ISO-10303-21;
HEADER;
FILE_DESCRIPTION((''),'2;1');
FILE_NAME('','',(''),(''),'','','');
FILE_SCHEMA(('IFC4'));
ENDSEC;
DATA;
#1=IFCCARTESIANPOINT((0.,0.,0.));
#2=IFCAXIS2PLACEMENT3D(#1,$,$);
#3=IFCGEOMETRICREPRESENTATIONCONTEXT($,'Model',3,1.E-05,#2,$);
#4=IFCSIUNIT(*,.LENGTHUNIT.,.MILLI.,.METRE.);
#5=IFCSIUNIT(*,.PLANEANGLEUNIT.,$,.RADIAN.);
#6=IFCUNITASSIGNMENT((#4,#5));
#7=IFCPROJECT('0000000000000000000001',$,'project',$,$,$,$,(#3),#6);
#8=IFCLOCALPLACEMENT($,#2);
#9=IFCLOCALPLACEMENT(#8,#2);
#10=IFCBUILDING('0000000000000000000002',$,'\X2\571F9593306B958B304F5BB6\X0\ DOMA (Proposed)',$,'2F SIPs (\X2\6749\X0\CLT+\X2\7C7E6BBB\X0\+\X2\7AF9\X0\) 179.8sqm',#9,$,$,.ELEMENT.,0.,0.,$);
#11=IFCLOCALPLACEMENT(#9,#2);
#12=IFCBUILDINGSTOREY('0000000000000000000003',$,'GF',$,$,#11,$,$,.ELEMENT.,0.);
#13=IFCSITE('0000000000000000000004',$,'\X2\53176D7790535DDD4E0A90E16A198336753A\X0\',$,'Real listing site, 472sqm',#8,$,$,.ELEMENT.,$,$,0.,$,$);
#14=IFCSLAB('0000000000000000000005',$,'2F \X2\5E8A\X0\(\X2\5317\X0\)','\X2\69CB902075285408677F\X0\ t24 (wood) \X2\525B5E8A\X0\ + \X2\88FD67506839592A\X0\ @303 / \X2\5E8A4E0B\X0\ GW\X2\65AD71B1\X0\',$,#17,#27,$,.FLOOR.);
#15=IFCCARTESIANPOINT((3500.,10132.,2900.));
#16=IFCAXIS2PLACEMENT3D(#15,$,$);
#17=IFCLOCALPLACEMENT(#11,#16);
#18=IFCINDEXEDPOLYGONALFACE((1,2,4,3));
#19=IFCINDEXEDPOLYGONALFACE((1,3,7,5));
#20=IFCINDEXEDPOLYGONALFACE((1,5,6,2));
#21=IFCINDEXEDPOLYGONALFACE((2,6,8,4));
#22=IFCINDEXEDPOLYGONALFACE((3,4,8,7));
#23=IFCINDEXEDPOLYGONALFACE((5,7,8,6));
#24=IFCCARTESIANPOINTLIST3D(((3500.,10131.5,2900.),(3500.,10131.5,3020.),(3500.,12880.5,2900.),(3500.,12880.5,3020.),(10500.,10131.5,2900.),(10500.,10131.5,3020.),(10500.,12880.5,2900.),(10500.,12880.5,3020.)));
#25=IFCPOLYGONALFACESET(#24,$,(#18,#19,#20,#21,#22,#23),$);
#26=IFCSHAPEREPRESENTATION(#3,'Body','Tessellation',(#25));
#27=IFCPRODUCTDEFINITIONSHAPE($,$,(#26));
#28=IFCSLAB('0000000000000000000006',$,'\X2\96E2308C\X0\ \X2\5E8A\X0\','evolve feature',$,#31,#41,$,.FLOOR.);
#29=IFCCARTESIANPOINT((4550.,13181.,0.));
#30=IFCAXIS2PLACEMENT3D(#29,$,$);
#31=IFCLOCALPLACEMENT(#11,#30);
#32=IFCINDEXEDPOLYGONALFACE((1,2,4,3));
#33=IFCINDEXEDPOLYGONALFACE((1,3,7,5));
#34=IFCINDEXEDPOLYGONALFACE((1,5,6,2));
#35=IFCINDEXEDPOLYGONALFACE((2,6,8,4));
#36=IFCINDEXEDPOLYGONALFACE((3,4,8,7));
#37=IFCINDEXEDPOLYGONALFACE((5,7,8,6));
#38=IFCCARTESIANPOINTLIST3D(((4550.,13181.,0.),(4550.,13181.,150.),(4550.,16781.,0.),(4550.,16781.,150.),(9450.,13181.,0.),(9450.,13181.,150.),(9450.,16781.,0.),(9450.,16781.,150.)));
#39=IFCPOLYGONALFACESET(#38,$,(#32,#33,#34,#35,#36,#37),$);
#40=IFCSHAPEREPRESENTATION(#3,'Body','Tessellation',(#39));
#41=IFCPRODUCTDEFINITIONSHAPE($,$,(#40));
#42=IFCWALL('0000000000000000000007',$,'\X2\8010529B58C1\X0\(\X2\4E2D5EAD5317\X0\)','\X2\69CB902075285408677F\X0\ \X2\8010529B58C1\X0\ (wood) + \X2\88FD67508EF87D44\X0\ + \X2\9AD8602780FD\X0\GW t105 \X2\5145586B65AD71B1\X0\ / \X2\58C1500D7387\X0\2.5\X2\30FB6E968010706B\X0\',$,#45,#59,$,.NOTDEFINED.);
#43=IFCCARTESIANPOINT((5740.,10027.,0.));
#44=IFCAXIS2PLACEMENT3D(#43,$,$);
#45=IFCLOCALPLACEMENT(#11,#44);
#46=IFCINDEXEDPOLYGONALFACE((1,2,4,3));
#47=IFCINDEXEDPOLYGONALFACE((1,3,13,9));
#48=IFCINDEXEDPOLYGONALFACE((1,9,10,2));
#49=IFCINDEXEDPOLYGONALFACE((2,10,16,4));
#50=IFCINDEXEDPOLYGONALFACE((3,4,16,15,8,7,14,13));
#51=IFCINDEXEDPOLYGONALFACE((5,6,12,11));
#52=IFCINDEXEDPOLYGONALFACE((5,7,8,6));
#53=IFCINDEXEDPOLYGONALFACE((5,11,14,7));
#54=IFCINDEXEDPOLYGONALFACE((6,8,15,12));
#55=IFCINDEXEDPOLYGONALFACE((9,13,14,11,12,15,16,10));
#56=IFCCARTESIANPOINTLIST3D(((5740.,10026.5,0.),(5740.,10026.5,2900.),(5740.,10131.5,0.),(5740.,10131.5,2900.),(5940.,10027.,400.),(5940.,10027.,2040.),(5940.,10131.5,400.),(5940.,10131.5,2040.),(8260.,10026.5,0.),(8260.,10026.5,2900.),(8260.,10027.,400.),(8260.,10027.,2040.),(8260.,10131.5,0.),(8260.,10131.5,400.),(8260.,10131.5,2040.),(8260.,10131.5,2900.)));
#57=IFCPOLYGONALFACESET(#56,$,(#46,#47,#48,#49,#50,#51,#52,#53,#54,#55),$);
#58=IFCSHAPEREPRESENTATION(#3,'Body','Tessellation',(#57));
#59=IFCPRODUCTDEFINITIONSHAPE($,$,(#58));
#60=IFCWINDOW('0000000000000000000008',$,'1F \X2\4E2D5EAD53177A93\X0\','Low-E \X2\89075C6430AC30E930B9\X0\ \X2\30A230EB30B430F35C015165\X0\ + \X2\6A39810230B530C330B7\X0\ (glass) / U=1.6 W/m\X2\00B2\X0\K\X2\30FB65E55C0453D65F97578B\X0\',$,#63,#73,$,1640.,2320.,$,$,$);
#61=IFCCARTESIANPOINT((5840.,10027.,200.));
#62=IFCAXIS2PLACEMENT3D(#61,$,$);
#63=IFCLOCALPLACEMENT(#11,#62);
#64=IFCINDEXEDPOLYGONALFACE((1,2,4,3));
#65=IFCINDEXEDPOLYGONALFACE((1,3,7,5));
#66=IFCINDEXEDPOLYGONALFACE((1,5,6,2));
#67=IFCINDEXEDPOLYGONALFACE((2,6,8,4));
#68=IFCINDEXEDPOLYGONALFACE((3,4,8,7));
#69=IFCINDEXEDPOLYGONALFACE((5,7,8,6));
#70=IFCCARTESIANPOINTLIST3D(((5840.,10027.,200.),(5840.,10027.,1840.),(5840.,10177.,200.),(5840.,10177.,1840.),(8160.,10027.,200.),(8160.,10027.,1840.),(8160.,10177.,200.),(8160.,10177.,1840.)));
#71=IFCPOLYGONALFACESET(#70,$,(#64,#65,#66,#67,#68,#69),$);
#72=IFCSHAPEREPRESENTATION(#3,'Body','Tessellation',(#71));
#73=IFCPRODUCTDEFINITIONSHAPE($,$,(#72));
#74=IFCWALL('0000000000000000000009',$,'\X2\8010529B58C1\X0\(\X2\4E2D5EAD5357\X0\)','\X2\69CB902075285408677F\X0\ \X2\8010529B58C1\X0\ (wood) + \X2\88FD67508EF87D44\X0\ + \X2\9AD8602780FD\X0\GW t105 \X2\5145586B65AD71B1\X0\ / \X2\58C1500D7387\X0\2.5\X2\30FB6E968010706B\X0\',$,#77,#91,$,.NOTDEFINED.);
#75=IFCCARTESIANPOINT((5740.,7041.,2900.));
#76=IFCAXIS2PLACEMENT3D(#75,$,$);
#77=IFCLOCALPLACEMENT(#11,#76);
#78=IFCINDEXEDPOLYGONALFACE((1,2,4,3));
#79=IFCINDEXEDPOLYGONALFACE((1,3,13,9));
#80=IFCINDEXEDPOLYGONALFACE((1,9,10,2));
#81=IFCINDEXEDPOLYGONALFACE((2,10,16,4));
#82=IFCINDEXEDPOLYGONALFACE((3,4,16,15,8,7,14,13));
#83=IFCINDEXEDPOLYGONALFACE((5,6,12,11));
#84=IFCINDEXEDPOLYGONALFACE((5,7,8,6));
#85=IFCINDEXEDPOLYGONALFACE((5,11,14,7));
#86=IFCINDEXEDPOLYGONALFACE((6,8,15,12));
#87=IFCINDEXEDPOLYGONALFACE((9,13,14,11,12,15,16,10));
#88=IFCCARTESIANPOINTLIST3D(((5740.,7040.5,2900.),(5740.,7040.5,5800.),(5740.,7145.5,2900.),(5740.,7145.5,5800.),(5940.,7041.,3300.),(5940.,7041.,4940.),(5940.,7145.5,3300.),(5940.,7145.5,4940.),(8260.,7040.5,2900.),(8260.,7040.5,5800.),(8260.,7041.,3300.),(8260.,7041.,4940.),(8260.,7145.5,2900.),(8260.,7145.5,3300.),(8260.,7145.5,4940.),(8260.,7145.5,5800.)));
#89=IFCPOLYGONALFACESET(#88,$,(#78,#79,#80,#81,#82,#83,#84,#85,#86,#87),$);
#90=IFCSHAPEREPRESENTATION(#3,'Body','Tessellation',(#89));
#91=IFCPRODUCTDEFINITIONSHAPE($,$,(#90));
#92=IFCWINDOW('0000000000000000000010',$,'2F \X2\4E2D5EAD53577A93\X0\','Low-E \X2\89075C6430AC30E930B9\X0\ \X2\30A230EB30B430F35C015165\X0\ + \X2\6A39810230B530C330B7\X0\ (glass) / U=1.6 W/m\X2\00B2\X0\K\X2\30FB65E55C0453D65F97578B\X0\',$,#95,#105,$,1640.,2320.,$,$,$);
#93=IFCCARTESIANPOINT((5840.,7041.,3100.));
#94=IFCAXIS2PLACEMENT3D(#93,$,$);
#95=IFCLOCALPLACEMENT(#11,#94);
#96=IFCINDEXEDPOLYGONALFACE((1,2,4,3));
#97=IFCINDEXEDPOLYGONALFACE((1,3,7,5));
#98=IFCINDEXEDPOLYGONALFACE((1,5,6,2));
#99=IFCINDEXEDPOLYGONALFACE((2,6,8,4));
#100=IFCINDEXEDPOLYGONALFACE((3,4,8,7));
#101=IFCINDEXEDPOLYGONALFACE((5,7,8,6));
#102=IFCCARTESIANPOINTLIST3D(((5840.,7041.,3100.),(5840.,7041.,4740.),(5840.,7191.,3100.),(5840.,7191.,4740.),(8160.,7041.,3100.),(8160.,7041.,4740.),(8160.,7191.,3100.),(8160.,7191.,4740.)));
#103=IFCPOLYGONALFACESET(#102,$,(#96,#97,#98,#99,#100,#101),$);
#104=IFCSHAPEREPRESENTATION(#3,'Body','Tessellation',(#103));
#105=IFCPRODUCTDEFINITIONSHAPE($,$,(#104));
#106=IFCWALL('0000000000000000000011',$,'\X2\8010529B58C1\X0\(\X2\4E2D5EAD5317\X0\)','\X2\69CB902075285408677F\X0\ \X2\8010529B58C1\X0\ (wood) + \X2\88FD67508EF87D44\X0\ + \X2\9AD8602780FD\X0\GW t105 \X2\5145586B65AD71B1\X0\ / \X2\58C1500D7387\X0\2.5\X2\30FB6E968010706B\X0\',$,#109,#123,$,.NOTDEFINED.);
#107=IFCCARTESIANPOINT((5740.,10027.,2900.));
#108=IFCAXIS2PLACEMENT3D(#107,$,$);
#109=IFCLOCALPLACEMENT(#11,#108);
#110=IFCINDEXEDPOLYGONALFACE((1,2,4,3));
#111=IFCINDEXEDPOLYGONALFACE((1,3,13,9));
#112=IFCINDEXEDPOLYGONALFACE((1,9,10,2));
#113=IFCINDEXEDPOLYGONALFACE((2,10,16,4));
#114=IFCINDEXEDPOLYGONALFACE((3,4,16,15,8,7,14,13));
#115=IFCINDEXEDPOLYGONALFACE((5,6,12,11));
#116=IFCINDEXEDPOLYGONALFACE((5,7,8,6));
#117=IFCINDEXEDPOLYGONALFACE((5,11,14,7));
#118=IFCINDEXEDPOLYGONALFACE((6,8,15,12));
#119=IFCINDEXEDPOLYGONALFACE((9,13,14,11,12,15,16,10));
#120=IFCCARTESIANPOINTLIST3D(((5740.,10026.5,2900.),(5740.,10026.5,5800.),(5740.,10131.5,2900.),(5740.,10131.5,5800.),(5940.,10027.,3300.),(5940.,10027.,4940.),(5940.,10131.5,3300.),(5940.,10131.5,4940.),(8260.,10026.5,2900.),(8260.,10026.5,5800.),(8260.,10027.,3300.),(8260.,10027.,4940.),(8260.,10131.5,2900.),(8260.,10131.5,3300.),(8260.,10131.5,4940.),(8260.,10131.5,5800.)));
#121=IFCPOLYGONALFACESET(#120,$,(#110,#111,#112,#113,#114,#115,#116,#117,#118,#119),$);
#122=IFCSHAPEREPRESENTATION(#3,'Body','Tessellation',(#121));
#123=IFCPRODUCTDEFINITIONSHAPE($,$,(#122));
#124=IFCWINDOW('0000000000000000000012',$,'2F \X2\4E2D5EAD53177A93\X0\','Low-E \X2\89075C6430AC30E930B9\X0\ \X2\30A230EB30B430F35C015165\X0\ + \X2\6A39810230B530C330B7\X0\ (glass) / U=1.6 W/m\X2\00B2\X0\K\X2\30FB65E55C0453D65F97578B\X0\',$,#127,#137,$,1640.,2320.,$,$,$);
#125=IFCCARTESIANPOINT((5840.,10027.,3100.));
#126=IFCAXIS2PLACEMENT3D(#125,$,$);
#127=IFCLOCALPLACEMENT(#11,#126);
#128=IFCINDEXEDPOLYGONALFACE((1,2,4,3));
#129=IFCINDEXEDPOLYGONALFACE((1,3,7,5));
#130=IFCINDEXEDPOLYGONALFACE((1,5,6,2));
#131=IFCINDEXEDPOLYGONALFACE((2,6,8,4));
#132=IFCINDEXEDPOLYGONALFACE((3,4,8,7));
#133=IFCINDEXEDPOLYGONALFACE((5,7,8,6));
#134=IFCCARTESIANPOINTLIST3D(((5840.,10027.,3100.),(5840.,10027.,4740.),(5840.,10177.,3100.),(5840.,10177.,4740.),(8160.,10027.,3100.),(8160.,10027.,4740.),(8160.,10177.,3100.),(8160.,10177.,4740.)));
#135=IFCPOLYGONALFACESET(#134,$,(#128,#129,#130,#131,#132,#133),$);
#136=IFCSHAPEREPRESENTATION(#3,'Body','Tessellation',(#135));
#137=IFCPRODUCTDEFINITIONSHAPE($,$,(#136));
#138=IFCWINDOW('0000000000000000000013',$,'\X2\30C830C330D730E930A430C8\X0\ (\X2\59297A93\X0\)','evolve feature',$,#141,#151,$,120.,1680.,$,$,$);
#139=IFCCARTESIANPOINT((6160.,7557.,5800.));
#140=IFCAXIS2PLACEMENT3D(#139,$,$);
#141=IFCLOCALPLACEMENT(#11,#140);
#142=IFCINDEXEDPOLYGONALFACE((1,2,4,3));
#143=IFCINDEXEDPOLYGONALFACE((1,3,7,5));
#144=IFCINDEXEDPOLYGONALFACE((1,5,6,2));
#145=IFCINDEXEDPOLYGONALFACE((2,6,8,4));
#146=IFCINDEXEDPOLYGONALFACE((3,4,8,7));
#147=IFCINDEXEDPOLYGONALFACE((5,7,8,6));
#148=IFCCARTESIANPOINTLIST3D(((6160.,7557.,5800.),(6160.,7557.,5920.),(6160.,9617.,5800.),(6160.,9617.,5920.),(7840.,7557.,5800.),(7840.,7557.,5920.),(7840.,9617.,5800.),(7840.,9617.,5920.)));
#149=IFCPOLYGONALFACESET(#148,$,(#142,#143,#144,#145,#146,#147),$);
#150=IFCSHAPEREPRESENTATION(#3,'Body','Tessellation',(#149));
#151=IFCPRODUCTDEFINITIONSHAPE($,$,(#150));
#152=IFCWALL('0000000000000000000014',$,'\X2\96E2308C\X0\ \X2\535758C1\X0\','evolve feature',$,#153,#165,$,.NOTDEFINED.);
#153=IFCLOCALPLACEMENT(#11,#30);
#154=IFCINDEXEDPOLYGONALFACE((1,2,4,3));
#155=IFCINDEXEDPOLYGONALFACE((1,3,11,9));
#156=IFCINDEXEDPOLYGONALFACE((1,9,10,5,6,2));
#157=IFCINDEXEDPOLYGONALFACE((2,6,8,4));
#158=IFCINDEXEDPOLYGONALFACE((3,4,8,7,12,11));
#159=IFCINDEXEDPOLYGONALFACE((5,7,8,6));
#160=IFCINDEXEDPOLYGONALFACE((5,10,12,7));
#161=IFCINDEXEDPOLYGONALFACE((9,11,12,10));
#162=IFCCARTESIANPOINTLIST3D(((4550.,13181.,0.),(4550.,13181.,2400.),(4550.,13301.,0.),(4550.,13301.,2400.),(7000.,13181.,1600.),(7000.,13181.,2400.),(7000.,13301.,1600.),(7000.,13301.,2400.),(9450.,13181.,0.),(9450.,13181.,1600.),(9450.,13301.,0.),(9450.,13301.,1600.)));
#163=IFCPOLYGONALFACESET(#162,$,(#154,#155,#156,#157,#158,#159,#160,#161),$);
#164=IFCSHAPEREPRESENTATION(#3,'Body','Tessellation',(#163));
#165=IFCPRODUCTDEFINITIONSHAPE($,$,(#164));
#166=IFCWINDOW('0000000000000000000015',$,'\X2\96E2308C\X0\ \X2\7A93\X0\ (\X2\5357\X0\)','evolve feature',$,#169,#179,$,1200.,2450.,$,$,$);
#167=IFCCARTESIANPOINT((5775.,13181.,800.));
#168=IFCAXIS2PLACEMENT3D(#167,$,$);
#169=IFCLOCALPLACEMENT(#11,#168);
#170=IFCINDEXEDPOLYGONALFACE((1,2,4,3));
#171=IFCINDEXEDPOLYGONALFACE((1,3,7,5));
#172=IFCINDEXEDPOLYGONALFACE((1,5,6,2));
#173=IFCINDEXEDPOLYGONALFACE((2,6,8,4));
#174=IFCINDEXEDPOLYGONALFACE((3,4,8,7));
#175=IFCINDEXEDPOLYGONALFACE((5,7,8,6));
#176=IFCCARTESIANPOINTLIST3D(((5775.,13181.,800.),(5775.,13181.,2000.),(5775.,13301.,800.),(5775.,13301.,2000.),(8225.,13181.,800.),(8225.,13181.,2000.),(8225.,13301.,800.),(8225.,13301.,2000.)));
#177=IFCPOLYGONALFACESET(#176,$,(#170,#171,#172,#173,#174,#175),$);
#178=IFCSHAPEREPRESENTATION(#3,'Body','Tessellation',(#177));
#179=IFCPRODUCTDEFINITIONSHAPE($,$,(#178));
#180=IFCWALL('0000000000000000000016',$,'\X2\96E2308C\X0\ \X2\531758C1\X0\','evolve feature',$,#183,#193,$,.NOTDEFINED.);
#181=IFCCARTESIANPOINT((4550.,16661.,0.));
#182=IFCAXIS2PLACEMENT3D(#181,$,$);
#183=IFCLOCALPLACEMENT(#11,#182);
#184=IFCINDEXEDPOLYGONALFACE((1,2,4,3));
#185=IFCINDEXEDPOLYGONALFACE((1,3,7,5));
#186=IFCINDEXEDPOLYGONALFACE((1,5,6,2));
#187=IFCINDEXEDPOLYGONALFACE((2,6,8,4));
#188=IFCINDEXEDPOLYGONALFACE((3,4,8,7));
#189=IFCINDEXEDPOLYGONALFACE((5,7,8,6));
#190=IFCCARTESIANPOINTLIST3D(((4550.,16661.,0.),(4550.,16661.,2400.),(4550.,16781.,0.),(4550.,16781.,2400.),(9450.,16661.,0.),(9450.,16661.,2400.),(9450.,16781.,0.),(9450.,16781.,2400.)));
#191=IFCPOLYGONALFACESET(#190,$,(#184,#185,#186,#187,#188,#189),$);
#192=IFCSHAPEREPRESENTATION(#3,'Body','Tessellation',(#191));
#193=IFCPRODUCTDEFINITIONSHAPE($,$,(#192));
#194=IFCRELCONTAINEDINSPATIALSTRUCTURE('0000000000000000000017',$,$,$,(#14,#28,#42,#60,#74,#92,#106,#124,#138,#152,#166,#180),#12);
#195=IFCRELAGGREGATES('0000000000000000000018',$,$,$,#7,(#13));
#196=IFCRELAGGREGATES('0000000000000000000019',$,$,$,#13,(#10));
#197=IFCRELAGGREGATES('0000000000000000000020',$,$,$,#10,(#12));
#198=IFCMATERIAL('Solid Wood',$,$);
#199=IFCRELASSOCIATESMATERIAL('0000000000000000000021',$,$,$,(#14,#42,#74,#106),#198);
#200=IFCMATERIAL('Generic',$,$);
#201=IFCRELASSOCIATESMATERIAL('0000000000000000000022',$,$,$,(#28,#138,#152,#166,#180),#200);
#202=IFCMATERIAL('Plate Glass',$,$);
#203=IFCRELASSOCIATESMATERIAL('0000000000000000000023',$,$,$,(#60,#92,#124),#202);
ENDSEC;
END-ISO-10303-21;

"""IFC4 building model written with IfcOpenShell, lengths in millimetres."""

from ifc_helpers import new_model, si_unit, frame, frame_2d, origin, place, context, project, spatial, rectangle, extrude, material, element, fill, save


model = new_model("IFC4")

# Units and contexts
model_context = context("Model", 3, precision=1e-05, world=origin())
ifc_project = project(units=[si_unit("LENGTHUNIT", "METRE", prefix="MILLI"), si_unit("PLANEANGLEUNIT", "RADIAN")], contexts=[model_context])

# Site, building, storey
site_placement = place(None, origin())
site = spatial("IfcSite", under=ifc_project, at=site_placement, Name="北海道川上郡標茶町", ObjectType="Real listing site, 472sqm", CompositionType="ELEMENT", RefElevation=0.0)
building_placement = place(site_placement, origin())
building = spatial("IfcBuilding", under=site, at=building_placement, Name="土間に開く家 DOMA (Proposed)", ObjectType="2F SIPs (杉CLT+籾殻+竹) 179.8sqm", CompositionType="ELEMENT", ElevationOfRefHeight=0.0, ElevationOfTerrain=0.0)
storey_placement = place(building_placement, origin())
storey = spatial("IfcBuildingStorey", under=building, at=storey_placement, Name="GF", CompositionType="ELEMENT", Elevation=0.0)

# Slabs
ifc_material_1 = material(Name="Solid Wood")
slab_1_placement = place(storey_placement, frame((3500.0, 10132.0, 2900.0)))
element("IfcSlab", 1, at=slab_1_placement, inside=storey, material=ifc_material_1, Name="2F 床(北)", Description="構造用合板 t24 (wood) 剛床 + 製材根太 @303 / 床下 GW断熱", PredefinedType="FLOOR", context=model_context, shape_type="SweptSolid", body=[
    extrude(rectangle(XDim=7000.0, YDim=2749.0, at=frame_2d((3500.0, 1374.0))), frame((3500.0, 10132.0, 2900.0)), (0.0, 0.0, 1.0), 120.0),
])
ifc_material_2 = material(Name="Generic")
slab_2_placement = place(storey_placement, frame((4550.0, 13181.0, 0.0)))
element("IfcSlab", 2, at=slab_2_placement, inside=storey, material=ifc_material_2, Name="離れ 床", Description="evolve feature", PredefinedType="FLOOR", context=model_context, shape_type="SweptSolid", body=[
    extrude(rectangle(XDim=4900.0, YDim=3600.0, at=frame_2d((2450.0, 1800.0))), frame((4550.0, 13181.0, 0.0)), (0.0, 0.0, 1.0), 150.0),
])

# Wall, opening, window
wall_1_placement = place(storey_placement, frame((5740.0, 10027.0, 0.0)))
wall_1 = element("IfcWall", 3, at=wall_1_placement, inside=storey, material=ifc_material_1, Name="耐力壁(中庭北)", Description="構造用合板 耐力壁 (wood) + 製材軸組 + 高性能GW t105 充填断熱 / 壁倍率2.5・準耐火", PredefinedType="NOTDEFINED", context=model_context, shape_type="SweptSolid", body=[
    extrude(rectangle(XDim=2520.0, YDim=105.0, at=frame_2d((1260.0, 52.0))), frame((5740.0, 10027.0, 0.0)), (0.0, 0.0, 1.0), 2900.0),
])
opening_1_placement = place(storey_placement, frame((5840.0, 10027.0, 200.0)))
opening_1 = element("IfcOpeningElement", 4, at=opening_1_placement, cuts=wall_1, PredefinedType="NOTDEFINED", context=model_context, shape_type="SweptSolid", body=[
    extrude(rectangle(XDim=2320.0, YDim=150.0, at=frame_2d((1160.0, 75.0))), frame((5840.0, 10027.0, 200.0)), (0.0, 0.0, 1.0), 1640.0),
])
ifc_material_3 = material(Name="Plate Glass")
window_1_placement = place(storey_placement, frame((5840.0, 10027.0, 200.0)))
window_1 = element("IfcWindow", 5, at=window_1_placement, inside=storey, material=ifc_material_3, Name="1F 中庭北窓", Description="Low-E 複層ガラス アルゴン封入 + 樹脂サッシ (glass) / U=1.6 W/m²K・日射取得型", OverallHeight=1640.0, OverallWidth=2320.0, context=model_context, shape_type="SweptSolid", body=[
    extrude(rectangle(XDim=2320.0, YDim=150.0, at=frame_2d((1160.0, 75.0))), frame((5840.0, 10027.0, 200.0)), (0.0, 0.0, 1.0), 1640.0),
])
fill(opening_1, window_1)

# Walls, openings, windows
wall_2_placement = place(storey_placement, frame((5740.0, 7041.0, 2900.0)))
wall_2 = element("IfcWall", 6, at=wall_2_placement, inside=storey, material=ifc_material_1, Name="耐力壁(中庭南)", Description="構造用合板 耐力壁 (wood) + 製材軸組 + 高性能GW t105 充填断熱 / 壁倍率2.5・準耐火", PredefinedType="NOTDEFINED", context=model_context, shape_type="SweptSolid", body=[
    extrude(rectangle(XDim=2520.0, YDim=105.0, at=frame_2d((1260.0, 52.0))), frame((5740.0, 7041.0, 2900.0)), (0.0, 0.0, 1.0), 2900.0),
])
opening_2_placement = place(storey_placement, frame((5840.0, 7041.0, 3100.0)))
opening_2 = element("IfcOpeningElement", 7, at=opening_2_placement, cuts=wall_2, PredefinedType="NOTDEFINED", context=model_context, shape_type="SweptSolid", body=[
    extrude(rectangle(XDim=2320.0, YDim=150.0, at=frame_2d((1160.0, 75.0))), frame((5840.0, 7041.0, 3100.0)), (0.0, 0.0, 1.0), 1640.0),
])
window_2_placement = place(storey_placement, frame((5840.0, 7041.0, 3100.0)))
window_2 = element("IfcWindow", 8, at=window_2_placement, inside=storey, material=ifc_material_3, Name="2F 中庭南窓", Description="Low-E 複層ガラス アルゴン封入 + 樹脂サッシ (glass) / U=1.6 W/m²K・日射取得型", OverallHeight=1640.0, OverallWidth=2320.0, context=model_context, shape_type="SweptSolid", body=[
    extrude(rectangle(XDim=2320.0, YDim=150.0, at=frame_2d((1160.0, 75.0))), frame((5840.0, 7041.0, 3100.0)), (0.0, 0.0, 1.0), 1640.0),
])
fill(opening_2, window_2)
wall_3_placement = place(storey_placement, frame((5740.0, 10027.0, 2900.0)))
wall_3 = element("IfcWall", 9, at=wall_3_placement, inside=storey, material=ifc_material_1, Name="耐力壁(中庭北)", Description="構造用合板 耐力壁 (wood) + 製材軸組 + 高性能GW t105 充填断熱 / 壁倍率2.5・準耐火", PredefinedType="NOTDEFINED", context=model_context, shape_type="SweptSolid", body=[
    extrude(rectangle(XDim=2520.0, YDim=105.0, at=frame_2d((1260.0, 52.0))), frame((5740.0, 10027.0, 2900.0)), (0.0, 0.0, 1.0), 2900.0),
])
opening_3_placement = place(storey_placement, frame((5840.0, 10027.0, 3100.0)))
opening_3 = element("IfcOpeningElement", 10, at=opening_3_placement, cuts=wall_3, PredefinedType="NOTDEFINED", context=model_context, shape_type="SweptSolid", body=[
    extrude(rectangle(XDim=2320.0, YDim=150.0, at=frame_2d((1160.0, 75.0))), frame((5840.0, 10027.0, 3100.0)), (0.0, 0.0, 1.0), 1640.0),
])
window_3_placement = place(storey_placement, frame((5840.0, 10027.0, 3100.0)))
window_3 = element("IfcWindow", 11, at=window_3_placement, inside=storey, material=ifc_material_3, Name="2F 中庭北窓", Description="Low-E 複層ガラス アルゴン封入 + 樹脂サッシ (glass) / U=1.6 W/m²K・日射取得型", OverallHeight=1640.0, OverallWidth=2320.0, context=model_context, shape_type="SweptSolid", body=[
    extrude(rectangle(XDim=2320.0, YDim=150.0, at=frame_2d((1160.0, 75.0))), frame((5840.0, 10027.0, 3100.0)), (0.0, 0.0, 1.0), 1640.0),
])
fill(opening_3, window_3)

# Window
window_4_placement = place(storey_placement, frame((6160.0, 7557.0, 5800.0)))
element("IfcWindow", 12, at=window_4_placement, inside=storey, material=ifc_material_2, Name="トップライト (天窓)", Description="evolve feature", OverallHeight=120.0, OverallWidth=1680.0, context=model_context, shape_type="SweptSolid", body=[
    extrude(rectangle(XDim=1680.0, YDim=2060.0, at=frame_2d((840.0, 1030.0))), frame((6160.0, 7557.0, 5800.0)), (0.0, 0.0, 1.0), 120.0),
])

# Wall, opening, window
wall_4_placement = place(storey_placement, frame((4550.0, 13181.0, 0.0)))
wall_4 = element("IfcWall", 13, at=wall_4_placement, inside=storey, material=ifc_material_2, Name="離れ 南壁", Description="evolve feature", PredefinedType="NOTDEFINED", context=model_context, shape_type="SweptSolid", body=[
    extrude(rectangle(XDim=4900.0, YDim=120.0, at=frame_2d((2450.0, 60.0))), frame((4550.0, 13181.0, 0.0)), (0.0, 0.0, 1.0), 2400.0),
])
opening_4_placement = place(storey_placement, frame((5775.0, 13181.0, 800.0)))
opening_4 = element("IfcOpeningElement", 14, at=opening_4_placement, cuts=wall_4, PredefinedType="NOTDEFINED", context=model_context, shape_type="SweptSolid", body=[
    extrude(rectangle(XDim=2450.0, YDim=120.0, at=frame_2d((1225.0, 60.0))), frame((5775.0, 13181.0, 800.0)), (0.0, 0.0, 1.0), 1200.0),
])
window_5_placement = place(storey_placement, frame((5775.0, 13181.0, 800.0)))
window_5 = element("IfcWindow", 15, at=window_5_placement, inside=storey, material=ifc_material_2, Name="離れ 窓 (南)", Description="evolve feature", OverallHeight=1200.0, OverallWidth=2450.0, context=model_context, shape_type="SweptSolid", body=[
    extrude(rectangle(XDim=2450.0, YDim=120.0, at=frame_2d((1225.0, 60.0))), frame((5775.0, 13181.0, 800.0)), (0.0, 0.0, 1.0), 1200.0),
])
fill(opening_4, window_5)

# Wall
wall_5_placement = place(storey_placement, frame((4550.0, 16661.0, 0.0)))
element("IfcWall", 16, at=wall_5_placement, inside=storey, material=ifc_material_2, Name="離れ 北壁", Description="evolve feature", PredefinedType="NOTDEFINED", context=model_context, shape_type="SweptSolid", body=[
    extrude(rectangle(XDim=4900.0, YDim=120.0, at=frame_2d((2450.0, 60.0))), frame((4550.0, 16661.0, 0.0)), (0.0, 0.0, 1.0), 2400.0),
])

save(model, "model.ifc")
